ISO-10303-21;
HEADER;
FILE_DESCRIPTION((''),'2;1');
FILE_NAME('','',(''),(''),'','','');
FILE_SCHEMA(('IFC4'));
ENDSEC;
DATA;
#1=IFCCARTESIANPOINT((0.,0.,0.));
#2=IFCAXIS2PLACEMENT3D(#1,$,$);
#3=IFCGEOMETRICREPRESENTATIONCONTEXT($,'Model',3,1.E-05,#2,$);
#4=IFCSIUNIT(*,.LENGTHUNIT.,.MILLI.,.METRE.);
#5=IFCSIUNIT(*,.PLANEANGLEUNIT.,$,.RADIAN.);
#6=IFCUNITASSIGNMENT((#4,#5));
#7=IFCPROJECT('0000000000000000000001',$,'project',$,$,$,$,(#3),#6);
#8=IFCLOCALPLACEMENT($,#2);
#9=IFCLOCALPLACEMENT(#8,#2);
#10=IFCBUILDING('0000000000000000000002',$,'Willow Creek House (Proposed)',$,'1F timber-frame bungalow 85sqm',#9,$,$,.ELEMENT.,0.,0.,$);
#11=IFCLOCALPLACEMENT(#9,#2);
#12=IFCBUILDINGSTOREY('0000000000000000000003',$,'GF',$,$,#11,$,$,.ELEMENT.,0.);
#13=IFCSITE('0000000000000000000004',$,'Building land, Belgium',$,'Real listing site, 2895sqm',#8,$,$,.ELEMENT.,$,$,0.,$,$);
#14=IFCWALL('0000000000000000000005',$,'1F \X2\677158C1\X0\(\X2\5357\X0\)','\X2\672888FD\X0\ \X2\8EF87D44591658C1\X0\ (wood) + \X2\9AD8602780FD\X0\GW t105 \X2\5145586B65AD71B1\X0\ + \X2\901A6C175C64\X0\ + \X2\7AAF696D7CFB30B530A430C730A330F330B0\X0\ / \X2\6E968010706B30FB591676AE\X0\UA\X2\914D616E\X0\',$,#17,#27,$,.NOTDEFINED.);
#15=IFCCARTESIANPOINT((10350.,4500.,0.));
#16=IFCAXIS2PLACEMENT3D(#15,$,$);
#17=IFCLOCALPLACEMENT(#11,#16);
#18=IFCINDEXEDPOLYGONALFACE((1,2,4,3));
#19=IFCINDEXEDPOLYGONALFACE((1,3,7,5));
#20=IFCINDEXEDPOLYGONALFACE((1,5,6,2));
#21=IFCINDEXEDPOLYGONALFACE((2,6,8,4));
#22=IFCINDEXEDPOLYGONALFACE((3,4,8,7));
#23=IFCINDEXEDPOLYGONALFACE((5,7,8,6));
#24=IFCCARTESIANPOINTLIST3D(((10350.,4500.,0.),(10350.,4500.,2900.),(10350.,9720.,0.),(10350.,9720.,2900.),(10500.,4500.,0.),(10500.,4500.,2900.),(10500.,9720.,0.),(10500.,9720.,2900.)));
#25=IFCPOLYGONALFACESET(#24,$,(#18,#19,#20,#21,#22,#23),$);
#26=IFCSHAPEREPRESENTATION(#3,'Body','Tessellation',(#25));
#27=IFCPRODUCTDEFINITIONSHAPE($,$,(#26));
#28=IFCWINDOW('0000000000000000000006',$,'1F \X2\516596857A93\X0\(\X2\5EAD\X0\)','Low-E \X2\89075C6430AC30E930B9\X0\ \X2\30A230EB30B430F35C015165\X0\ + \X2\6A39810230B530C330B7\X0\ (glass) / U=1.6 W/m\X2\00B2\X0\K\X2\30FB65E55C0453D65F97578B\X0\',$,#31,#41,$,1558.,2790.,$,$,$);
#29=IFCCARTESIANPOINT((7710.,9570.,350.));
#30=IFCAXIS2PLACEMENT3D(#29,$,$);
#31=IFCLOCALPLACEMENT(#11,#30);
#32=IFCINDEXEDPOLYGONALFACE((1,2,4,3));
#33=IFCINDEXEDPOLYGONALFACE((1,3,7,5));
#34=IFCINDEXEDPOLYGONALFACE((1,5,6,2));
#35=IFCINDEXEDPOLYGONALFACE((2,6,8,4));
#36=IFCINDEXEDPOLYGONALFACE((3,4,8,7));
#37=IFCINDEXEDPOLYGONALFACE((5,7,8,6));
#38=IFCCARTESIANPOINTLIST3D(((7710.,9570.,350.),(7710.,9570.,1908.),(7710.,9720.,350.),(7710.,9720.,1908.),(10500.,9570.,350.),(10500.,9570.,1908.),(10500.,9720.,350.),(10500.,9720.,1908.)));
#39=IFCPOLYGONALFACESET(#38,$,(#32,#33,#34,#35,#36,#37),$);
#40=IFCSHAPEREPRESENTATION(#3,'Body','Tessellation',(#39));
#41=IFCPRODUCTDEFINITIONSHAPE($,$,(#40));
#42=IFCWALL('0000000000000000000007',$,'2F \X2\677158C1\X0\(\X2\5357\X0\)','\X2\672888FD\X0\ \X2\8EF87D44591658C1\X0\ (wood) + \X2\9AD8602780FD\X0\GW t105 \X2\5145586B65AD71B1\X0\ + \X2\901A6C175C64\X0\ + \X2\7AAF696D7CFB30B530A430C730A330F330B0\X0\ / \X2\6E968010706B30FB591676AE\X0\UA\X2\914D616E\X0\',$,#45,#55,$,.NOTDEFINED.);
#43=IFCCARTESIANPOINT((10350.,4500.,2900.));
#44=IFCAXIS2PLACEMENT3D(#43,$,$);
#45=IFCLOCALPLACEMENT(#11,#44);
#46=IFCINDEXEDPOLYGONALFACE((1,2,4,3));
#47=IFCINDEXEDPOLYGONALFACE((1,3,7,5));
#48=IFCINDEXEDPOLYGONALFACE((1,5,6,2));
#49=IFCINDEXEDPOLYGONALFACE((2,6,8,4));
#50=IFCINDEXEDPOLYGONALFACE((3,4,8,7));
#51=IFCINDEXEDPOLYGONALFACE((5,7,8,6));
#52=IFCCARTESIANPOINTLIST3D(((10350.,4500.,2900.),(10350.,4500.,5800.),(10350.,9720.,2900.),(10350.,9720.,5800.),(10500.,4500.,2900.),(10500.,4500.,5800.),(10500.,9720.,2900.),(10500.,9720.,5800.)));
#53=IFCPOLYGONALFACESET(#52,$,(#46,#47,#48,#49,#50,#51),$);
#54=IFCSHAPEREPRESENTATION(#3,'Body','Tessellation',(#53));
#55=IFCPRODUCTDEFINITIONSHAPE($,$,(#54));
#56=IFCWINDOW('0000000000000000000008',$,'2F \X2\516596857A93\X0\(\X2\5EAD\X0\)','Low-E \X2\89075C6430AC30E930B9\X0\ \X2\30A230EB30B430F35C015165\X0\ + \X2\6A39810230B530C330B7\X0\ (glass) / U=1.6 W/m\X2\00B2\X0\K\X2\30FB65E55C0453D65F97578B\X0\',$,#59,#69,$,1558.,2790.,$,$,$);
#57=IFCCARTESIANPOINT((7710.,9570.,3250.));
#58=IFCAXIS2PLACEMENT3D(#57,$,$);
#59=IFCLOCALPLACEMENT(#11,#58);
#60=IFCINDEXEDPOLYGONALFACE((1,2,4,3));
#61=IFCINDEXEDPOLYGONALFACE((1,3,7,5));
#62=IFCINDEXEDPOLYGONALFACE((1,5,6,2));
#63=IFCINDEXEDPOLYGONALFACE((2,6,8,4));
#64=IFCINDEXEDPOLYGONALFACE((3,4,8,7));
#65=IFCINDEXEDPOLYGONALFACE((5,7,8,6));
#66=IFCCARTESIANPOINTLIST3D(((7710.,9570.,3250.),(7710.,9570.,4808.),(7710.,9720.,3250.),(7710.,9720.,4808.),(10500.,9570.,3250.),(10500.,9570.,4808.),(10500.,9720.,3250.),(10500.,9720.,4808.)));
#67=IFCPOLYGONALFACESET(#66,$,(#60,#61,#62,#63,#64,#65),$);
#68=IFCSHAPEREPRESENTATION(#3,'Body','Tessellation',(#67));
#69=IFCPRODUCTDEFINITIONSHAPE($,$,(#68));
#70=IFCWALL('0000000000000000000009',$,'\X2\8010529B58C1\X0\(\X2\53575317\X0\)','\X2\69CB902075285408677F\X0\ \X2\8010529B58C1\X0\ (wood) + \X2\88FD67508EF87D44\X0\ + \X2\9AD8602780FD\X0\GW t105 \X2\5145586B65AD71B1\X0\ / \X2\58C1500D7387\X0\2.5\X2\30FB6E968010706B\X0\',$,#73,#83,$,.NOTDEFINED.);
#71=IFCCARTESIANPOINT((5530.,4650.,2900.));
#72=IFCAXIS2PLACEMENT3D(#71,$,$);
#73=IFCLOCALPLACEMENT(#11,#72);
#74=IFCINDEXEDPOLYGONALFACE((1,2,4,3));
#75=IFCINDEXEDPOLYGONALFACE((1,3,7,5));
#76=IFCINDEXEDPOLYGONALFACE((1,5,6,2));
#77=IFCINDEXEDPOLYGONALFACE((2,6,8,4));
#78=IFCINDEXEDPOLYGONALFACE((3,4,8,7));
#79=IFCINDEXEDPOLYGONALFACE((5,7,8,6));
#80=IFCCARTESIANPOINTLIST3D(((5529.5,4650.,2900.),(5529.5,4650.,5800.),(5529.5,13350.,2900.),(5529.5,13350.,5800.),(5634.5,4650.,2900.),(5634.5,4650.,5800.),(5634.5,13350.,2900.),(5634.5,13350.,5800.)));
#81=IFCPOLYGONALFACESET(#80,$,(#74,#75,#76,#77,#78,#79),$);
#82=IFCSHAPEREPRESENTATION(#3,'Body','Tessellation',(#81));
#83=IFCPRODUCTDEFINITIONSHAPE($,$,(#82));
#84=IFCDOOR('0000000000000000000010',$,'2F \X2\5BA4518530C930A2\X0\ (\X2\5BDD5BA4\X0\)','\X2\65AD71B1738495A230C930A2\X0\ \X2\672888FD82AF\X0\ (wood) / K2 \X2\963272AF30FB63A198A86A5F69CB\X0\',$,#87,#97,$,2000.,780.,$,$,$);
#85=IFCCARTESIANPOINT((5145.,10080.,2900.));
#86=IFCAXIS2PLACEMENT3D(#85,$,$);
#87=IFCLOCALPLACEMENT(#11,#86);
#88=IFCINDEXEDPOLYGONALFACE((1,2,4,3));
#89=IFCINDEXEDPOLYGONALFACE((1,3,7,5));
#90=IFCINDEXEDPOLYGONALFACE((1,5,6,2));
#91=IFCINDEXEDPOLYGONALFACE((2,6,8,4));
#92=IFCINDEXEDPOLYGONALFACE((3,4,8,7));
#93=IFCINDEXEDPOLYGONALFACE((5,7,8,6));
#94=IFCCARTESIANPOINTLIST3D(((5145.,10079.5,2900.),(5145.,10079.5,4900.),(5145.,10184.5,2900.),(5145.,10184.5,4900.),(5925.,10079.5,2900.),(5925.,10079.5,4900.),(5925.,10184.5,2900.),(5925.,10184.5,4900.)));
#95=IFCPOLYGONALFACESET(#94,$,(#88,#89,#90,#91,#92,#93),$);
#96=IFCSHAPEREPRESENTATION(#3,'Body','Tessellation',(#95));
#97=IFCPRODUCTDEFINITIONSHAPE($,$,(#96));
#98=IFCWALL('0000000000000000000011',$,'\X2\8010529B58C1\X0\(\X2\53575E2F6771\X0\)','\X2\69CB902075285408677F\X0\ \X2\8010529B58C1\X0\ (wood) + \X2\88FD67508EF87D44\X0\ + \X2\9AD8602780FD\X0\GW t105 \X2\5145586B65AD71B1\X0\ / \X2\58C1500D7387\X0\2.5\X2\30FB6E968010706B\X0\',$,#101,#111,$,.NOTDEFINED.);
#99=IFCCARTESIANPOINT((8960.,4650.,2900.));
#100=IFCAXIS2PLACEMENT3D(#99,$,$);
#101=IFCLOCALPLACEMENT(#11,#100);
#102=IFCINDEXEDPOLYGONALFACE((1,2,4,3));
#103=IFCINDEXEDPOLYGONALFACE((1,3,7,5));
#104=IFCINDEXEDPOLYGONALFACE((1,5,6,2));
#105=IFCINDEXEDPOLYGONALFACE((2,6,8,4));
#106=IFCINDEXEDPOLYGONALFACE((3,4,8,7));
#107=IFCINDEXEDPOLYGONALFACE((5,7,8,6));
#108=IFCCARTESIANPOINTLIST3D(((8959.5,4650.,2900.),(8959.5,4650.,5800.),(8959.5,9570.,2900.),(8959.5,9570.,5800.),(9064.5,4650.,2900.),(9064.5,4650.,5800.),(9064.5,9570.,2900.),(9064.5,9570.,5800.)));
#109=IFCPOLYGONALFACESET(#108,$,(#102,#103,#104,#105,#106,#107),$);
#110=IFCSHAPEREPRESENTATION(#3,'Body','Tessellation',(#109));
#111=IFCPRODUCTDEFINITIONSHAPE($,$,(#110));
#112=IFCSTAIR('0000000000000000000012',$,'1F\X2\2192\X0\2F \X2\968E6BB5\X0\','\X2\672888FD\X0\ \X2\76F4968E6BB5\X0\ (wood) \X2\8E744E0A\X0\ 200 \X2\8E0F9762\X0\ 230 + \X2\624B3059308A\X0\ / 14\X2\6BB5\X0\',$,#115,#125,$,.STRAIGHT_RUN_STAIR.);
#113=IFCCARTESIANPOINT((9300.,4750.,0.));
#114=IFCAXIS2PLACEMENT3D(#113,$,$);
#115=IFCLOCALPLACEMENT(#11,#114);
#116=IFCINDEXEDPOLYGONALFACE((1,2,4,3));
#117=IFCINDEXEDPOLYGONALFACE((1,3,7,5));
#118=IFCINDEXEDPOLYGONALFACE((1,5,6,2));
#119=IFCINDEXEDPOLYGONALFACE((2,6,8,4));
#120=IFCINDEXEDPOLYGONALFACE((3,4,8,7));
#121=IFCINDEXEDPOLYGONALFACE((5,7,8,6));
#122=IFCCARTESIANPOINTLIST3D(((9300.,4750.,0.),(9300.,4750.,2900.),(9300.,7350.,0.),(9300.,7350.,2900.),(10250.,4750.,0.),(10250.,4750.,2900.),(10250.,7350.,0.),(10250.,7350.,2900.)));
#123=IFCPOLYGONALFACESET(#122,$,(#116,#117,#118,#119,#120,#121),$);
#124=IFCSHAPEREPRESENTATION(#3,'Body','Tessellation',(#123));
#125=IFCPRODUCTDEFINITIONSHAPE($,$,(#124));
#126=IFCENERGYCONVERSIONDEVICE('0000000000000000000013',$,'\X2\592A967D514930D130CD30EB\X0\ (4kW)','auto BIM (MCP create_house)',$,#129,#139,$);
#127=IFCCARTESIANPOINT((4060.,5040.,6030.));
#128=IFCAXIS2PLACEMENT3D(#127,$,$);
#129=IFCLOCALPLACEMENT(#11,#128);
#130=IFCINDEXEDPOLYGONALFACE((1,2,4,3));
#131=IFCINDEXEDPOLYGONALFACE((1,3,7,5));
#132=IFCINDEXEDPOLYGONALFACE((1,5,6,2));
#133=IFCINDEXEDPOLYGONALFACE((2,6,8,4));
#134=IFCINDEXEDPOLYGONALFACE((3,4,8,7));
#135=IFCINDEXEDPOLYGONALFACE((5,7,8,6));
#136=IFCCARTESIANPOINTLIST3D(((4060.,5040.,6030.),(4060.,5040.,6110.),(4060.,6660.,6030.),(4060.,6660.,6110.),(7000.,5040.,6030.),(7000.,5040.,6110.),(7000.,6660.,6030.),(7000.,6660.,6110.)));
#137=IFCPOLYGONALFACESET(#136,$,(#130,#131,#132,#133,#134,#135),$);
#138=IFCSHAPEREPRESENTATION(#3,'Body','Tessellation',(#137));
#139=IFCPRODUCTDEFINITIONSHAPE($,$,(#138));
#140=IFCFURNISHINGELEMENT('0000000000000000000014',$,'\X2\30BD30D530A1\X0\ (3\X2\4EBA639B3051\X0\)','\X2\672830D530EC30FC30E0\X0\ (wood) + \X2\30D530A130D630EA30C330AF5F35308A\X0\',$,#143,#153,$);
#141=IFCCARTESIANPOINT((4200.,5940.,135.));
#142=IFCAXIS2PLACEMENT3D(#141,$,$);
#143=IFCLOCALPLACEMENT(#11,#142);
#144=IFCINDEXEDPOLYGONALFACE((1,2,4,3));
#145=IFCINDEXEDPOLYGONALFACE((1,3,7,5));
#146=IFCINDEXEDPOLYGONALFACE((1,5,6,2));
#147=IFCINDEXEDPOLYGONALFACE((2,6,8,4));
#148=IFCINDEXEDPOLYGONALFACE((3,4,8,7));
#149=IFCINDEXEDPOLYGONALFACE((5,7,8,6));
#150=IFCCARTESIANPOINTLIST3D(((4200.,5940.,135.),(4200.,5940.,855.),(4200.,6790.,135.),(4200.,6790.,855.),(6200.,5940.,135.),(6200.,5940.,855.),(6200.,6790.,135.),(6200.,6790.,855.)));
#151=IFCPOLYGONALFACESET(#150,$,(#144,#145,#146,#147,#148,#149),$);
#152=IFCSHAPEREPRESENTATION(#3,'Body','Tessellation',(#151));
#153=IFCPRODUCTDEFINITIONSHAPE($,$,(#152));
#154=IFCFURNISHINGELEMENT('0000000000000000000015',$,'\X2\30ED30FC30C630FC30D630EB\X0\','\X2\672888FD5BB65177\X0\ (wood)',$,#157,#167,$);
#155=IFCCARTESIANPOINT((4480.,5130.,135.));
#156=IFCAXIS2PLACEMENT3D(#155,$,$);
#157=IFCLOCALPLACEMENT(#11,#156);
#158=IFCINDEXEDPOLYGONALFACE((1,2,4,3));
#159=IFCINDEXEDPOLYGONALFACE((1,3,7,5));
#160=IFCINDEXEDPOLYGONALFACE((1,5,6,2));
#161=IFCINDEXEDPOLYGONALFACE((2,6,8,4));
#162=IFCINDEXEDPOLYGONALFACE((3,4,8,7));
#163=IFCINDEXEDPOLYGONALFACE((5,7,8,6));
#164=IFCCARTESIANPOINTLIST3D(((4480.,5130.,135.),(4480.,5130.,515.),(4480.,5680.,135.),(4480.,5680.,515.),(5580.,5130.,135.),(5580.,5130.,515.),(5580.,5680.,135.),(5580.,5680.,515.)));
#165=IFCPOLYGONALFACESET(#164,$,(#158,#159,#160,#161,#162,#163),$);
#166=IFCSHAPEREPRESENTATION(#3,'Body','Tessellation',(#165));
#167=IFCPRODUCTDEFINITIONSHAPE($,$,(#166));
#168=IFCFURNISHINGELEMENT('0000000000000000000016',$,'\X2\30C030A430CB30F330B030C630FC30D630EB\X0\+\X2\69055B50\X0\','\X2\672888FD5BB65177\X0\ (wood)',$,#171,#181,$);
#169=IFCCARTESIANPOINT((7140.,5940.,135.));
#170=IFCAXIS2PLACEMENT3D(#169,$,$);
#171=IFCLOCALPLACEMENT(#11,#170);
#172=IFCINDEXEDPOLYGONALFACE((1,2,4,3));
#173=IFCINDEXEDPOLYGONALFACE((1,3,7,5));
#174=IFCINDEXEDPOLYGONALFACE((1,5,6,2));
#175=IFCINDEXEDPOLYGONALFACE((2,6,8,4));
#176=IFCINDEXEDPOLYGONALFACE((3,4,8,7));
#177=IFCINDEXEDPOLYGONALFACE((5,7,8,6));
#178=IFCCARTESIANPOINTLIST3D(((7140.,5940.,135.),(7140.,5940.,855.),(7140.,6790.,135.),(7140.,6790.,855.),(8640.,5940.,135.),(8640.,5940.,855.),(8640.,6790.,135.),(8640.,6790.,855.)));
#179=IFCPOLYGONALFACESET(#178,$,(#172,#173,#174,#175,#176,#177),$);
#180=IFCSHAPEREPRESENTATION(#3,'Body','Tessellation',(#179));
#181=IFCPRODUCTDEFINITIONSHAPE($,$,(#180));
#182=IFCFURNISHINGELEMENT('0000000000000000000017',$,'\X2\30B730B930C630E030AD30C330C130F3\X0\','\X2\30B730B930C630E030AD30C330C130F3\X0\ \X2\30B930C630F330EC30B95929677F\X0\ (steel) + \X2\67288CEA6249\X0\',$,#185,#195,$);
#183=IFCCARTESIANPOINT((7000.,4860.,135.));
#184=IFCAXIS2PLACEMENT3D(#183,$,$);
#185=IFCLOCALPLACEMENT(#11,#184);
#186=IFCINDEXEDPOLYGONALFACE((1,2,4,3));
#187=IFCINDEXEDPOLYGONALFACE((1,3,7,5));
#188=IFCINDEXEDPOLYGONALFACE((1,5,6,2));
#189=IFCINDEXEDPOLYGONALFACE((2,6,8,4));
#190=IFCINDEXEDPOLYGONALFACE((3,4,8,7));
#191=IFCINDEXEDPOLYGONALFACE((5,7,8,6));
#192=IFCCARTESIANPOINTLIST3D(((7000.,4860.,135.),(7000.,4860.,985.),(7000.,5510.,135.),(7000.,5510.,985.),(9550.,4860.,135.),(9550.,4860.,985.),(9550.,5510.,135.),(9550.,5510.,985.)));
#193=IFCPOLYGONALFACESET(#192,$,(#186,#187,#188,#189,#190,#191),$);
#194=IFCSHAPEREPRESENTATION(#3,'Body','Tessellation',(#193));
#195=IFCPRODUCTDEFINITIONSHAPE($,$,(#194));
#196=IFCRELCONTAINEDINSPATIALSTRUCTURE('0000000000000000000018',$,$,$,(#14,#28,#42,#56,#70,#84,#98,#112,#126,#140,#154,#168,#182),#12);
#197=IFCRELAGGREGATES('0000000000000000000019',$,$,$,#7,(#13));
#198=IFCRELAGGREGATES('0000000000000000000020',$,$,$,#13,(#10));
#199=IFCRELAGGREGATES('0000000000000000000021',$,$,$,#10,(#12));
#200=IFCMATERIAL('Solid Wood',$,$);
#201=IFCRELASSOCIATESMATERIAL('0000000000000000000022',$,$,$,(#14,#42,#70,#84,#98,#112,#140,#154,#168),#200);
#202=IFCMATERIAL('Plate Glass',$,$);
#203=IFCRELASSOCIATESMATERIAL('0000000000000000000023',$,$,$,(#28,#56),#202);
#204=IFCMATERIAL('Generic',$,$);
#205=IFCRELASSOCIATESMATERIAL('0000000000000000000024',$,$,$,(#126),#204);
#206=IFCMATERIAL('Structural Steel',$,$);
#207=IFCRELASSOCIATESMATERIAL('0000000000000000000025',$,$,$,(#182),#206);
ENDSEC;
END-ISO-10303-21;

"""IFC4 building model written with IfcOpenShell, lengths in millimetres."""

from ifc_helpers import new_model, si_unit, frame, frame_2d, origin, place, context, project, spatial, rectangle, extrude, material, element, fill, save


model = new_model("IFC4")

# Units and contexts
model_context = context("Model", 3, precision=1e-05, world=origin())
ifc_project = project(units=[si_unit("LENGTHUNIT", "METRE", prefix="MILLI"), si_unit("PLANEANGLEUNIT", "RADIAN")], contexts=[model_context])

# Site, building, storey
site_placement = place(None, origin())
site = spatial("IfcSite", under=ifc_project, at=site_placement, Name="Building land, Belgium", ObjectType="Real listing site, 2895sqm", CompositionType="ELEMENT", RefElevation=0.0)
building_placement = place(site_placement, origin())
building = spatial("IfcBuilding", under=site, at=building_placement, Name="Willow Creek House (Proposed)", ObjectType="1F timber-frame bungalow 85sqm", CompositionType="ELEMENT", ElevationOfRefHeight=0.0, ElevationOfTerrain=0.0)
storey_placement = place(building_placement, origin())
storey = spatial("IfcBuildingStorey", under=building, at=storey_placement, Name="GF", CompositionType="ELEMENT", Elevation=0.0)

# Wall, opening, window
ifc_material_1 = material(Name="Solid Wood")
wall_1_placement = place(storey_placement, frame((10350.0, 4500.0, 0.0)))
wall_1 = element("IfcWall", 1, at=wall_1_placement, inside=storey, material=ifc_material_1, Name="1F 東壁(南)", Description="木製 軸組外壁 (wood) + 高性能GW t105 充填断熱 + 通気層 + 窯業系サイディング / 準耐火・外皮UA配慮", PredefinedType="NOTDEFINED", context=model_context, shape_type="SweptSolid", body=[
    extrude(rectangle(XDim=150.0, YDim=5220.0, at=frame_2d((75.0, 2610.0))), frame((10350.0, 4500.0, 0.0)), (0.0, 0.0, 1.0), 2900.0),
])
opening_1_placement = place(storey_placement, frame((7710.0, 9570.0, 350.0)))
opening_1 = element("IfcOpeningElement", 2, at=opening_1_placement, cuts=wall_1, PredefinedType="NOTDEFINED", context=model_context, shape_type="SweptSolid", body=[
    extrude(rectangle(XDim=2790.0, YDim=150.0, at=frame_2d((1395.0, 75.0))), frame((7710.0, 9570.0, 350.0)), (0.0, 0.0, 1.0), 1558.0),
])
ifc_material_2 = material(Name="Plate Glass")
window_1_placement = place(storey_placement, frame((7710.0, 9570.0, 350.0)))
window_1 = element("IfcWindow", 3, at=window_1_placement, inside=storey, material=ifc_material_2, Name="1F 入隅窓(庭)", Description="Low-E 複層ガラス アルゴン封入 + 樹脂サッシ (glass) / U=1.6 W/m²K・日射取得型", OverallHeight=1558.0, OverallWidth=2790.0, context=model_context, shape_type="SweptSolid", body=[
    extrude(rectangle(XDim=2790.0, YDim=150.0, at=frame_2d((1395.0, 75.0))), frame((7710.0, 9570.0, 350.0)), (0.0, 0.0, 1.0), 1558.0),
])
fill(opening_1, window_1)

# Wall, opening, window
wall_2_placement = place(storey_placement, frame((10350.0, 4500.0, 2900.0)))
wall_2 = element("IfcWall", 4, at=wall_2_placement, inside=storey, material=ifc_material_1, Name="2F 東壁(南)", Description="木製 軸組外壁 (wood) + 高性能GW t105 充填断熱 + 通気層 + 窯業系サイディング / 準耐火・外皮UA配慮", PredefinedType="NOTDEFINED", context=model_context, shape_type="SweptSolid", body=[
    extrude(rectangle(XDim=150.0, YDim=5220.0, at=frame_2d((75.0, 2610.0))), frame((10350.0, 4500.0, 2900.0)), (0.0, 0.0, 1.0), 2900.0),
])
opening_2_placement = place(storey_placement, frame((7710.0, 9570.0, 3250.0)))
opening_2 = element("IfcOpeningElement", 5, at=opening_2_placement, cuts=wall_2, PredefinedType="NOTDEFINED", context=model_context, shape_type="SweptSolid", body=[
    extrude(rectangle(XDim=2790.0, YDim=150.0, at=frame_2d((1395.0, 75.0))), frame((7710.0, 9570.0, 3250.0)), (0.0, 0.0, 1.0), 1558.0),
])
window_2_placement = place(storey_placement, frame((7710.0, 9570.0, 3250.0)))
window_2 = element("IfcWindow", 6, at=window_2_placement, inside=storey, material=ifc_material_2, Name="2F 入隅窓(庭)", Description="Low-E 複層ガラス アルゴン封入 + 樹脂サッシ (glass) / U=1.6 W/m²K・日射取得型", OverallHeight=1558.0, OverallWidth=2790.0, context=model_context, shape_type="SweptSolid", body=[
    extrude(rectangle(XDim=2790.0, YDim=150.0, at=frame_2d((1395.0, 75.0))), frame((7710.0, 9570.0, 3250.0)), (0.0, 0.0, 1.0), 1558.0),
])
fill(opening_2, window_2)

# Wall, opening, door
wall_3_placement = place(storey_placement, frame((5530.0, 4650.0, 2900.0)))
wall_3 = element("IfcWall", 7, at=wall_3_placement, inside=storey, material=ifc_material_1, Name="耐力壁(南北)", Description="構造用合板 耐力壁 (wood) + 製材軸組 + 高性能GW t105 充填断熱 / 壁倍率2.5・準耐火", PredefinedType="NOTDEFINED", context=model_context, shape_type="SweptSolid", body=[
    extrude(rectangle(XDim=105.0, YDim=8700.0, at=frame_2d((52.0, 4350.0))), frame((5530.0, 4650.0, 2900.0)), (0.0, 0.0, 1.0), 2900.0),
])
opening_3_placement = place(storey_placement, frame((5145.0, 10080.0, 2900.0)))
opening_3 = element("IfcOpeningElement", 8, at=opening_3_placement, cuts=wall_3, PredefinedType="NOTDEFINED", context=model_context, shape_type="SweptSolid", body=[
    extrude(rectangle(XDim=780.0, YDim=105.0, at=frame_2d((390.0, 52.0))), frame((5145.0, 10080.0, 2900.0)), (0.0, 0.0, 1.0), 2000.0),
])
door_1_placement = place(storey_placement, frame((5145.0, 10080.0, 2900.0)))
door_1 = element("IfcDoor", 9, at=door_1_placement, inside=storey, material=ifc_material_1, Name="2F 室内ドア (寝室)", Description="断熱玄関ドア 木製芯 (wood) / K2 防犯・採風機構", OverallHeight=2000.0, OverallWidth=780.0, context=model_context, shape_type="SweptSolid", body=[
    extrude(rectangle(XDim=780.0, YDim=105.0, at=frame_2d((390.0, 52.0))), frame((5145.0, 10080.0, 2900.0)), (0.0, 0.0, 1.0), 2000.0),
])
fill(opening_3, door_1)

# Wall
wall_4_placement = place(storey_placement, frame((8960.0, 4650.0, 2900.0)))
element("IfcWall", 10, at=wall_4_placement, inside=storey, material=ifc_material_1, Name="耐力壁(南帯東)", Description="構造用合板 耐力壁 (wood) + 製材軸組 + 高性能GW t105 充填断熱 / 壁倍率2.5・準耐火", PredefinedType="NOTDEFINED", context=model_context, shape_type="SweptSolid", body=[
    extrude(rectangle(XDim=105.0, YDim=4920.0, at=frame_2d((52.0, 2460.0))), frame((8960.0, 4650.0, 2900.0)), (0.0, 0.0, 1.0), 2900.0),
])

# Stair
stair_placement = place(storey_placement, frame((9300.0, 4750.0, 0.0)))
element("IfcStair", 11, at=stair_placement, inside=storey, material=ifc_material_1, Name="1F→2F 階段", Description="木製 直階段 (wood) 蹴上 200 踏面 230 + 手すり / 14段", PredefinedType="STRAIGHT_RUN_STAIR", context=model_context, shape_type="SweptSolid", body=[
    extrude(rectangle(XDim=950.0, YDim=2600.0, at=frame_2d((475.0, 1300.0))), frame((9300.0, 4750.0, 0.0)), (0.0, 0.0, 1.0), 2900.0),
])

# Energy conversion device
ifc_material_3 = material(Name="Generic")
energy_conversion_device_placement = place(storey_placement, frame((4060.0, 5040.0, 6030.0)))
element("IfcEnergyConversionDevice", 12, at=energy_conversion_device_placement, inside=storey, material=ifc_material_3, Name="太陽光パネル (4kW)", Description="auto BIM (MCP create_house)", context=model_context, shape_type="SweptSolid", body=[
    extrude(rectangle(XDim=2940.0, YDim=1620.0, at=frame_2d((1470.0, 810.0))), frame((4060.0, 5040.0, 6030.0)), (0.0, 0.0, 1.0), 80.0),
])

# Furnishing elements
furnishing_1_placement = place(storey_placement, frame((4200.0, 5940.0, 135.0)))
element("IfcFurnishingElement", 13, at=furnishing_1_placement, inside=storey, material=ifc_material_1, Name="ソファ (3人掛け)", Description="木フレーム (wood) + ファブリック張り", context=model_context, shape_type="SweptSolid", body=[
    extrude(rectangle(XDim=2000.0, YDim=850.0, at=frame_2d((1000.0, 425.0))), frame((4200.0, 5940.0, 135.0)), (0.0, 0.0, 1.0), 720.0),
])
furnishing_2_placement = place(storey_placement, frame((4480.0, 5130.0, 135.0)))
element("IfcFurnishingElement", 14, at=furnishing_2_placement, inside=storey, material=ifc_material_1, Name="ローテーブル", Description="木製家具 (wood)", context=model_context, shape_type="SweptSolid", body=[
    extrude(rectangle(XDim=1100.0, YDim=550.0, at=frame_2d((550.0, 275.0))), frame((4480.0, 5130.0, 135.0)), (0.0, 0.0, 1.0), 380.0),
])
furnishing_3_placement = place(storey_placement, frame((7140.0, 5940.0, 135.0)))
element("IfcFurnishingElement", 15, at=furnishing_3_placement, inside=storey, material=ifc_material_1, Name="ダイニングテーブル+椅子", Description="木製家具 (wood)", context=model_context, shape_type="SweptSolid", body=[
    extrude(rectangle(XDim=1500.0, YDim=850.0, at=frame_2d((750.0, 425.0))), frame((7140.0, 5940.0, 135.0)), (0.0, 0.0, 1.0), 720.0),
])
ifc_material_4 = material(Name="Structural Steel")
furnishing_4_placement = place(storey_placement, frame((7000.0, 4860.0, 135.0)))
element("IfcFurnishingElement", 16, at=furnishing_4_placement, inside=storey, material=ifc_material_4, Name="システムキッチン", Description="システムキッチン ステンレス天板 (steel) + 木質扉", context=model_context, shape_type="SweptSolid", body=[
    extrude(rectangle(XDim=2550.0, YDim=650.0, at=frame_2d((1275.0, 325.0))), frame((7000.0, 4860.0, 135.0)), (0.0, 0.0, 1.0), 850.0),
])

save(model, "model.ifc")
